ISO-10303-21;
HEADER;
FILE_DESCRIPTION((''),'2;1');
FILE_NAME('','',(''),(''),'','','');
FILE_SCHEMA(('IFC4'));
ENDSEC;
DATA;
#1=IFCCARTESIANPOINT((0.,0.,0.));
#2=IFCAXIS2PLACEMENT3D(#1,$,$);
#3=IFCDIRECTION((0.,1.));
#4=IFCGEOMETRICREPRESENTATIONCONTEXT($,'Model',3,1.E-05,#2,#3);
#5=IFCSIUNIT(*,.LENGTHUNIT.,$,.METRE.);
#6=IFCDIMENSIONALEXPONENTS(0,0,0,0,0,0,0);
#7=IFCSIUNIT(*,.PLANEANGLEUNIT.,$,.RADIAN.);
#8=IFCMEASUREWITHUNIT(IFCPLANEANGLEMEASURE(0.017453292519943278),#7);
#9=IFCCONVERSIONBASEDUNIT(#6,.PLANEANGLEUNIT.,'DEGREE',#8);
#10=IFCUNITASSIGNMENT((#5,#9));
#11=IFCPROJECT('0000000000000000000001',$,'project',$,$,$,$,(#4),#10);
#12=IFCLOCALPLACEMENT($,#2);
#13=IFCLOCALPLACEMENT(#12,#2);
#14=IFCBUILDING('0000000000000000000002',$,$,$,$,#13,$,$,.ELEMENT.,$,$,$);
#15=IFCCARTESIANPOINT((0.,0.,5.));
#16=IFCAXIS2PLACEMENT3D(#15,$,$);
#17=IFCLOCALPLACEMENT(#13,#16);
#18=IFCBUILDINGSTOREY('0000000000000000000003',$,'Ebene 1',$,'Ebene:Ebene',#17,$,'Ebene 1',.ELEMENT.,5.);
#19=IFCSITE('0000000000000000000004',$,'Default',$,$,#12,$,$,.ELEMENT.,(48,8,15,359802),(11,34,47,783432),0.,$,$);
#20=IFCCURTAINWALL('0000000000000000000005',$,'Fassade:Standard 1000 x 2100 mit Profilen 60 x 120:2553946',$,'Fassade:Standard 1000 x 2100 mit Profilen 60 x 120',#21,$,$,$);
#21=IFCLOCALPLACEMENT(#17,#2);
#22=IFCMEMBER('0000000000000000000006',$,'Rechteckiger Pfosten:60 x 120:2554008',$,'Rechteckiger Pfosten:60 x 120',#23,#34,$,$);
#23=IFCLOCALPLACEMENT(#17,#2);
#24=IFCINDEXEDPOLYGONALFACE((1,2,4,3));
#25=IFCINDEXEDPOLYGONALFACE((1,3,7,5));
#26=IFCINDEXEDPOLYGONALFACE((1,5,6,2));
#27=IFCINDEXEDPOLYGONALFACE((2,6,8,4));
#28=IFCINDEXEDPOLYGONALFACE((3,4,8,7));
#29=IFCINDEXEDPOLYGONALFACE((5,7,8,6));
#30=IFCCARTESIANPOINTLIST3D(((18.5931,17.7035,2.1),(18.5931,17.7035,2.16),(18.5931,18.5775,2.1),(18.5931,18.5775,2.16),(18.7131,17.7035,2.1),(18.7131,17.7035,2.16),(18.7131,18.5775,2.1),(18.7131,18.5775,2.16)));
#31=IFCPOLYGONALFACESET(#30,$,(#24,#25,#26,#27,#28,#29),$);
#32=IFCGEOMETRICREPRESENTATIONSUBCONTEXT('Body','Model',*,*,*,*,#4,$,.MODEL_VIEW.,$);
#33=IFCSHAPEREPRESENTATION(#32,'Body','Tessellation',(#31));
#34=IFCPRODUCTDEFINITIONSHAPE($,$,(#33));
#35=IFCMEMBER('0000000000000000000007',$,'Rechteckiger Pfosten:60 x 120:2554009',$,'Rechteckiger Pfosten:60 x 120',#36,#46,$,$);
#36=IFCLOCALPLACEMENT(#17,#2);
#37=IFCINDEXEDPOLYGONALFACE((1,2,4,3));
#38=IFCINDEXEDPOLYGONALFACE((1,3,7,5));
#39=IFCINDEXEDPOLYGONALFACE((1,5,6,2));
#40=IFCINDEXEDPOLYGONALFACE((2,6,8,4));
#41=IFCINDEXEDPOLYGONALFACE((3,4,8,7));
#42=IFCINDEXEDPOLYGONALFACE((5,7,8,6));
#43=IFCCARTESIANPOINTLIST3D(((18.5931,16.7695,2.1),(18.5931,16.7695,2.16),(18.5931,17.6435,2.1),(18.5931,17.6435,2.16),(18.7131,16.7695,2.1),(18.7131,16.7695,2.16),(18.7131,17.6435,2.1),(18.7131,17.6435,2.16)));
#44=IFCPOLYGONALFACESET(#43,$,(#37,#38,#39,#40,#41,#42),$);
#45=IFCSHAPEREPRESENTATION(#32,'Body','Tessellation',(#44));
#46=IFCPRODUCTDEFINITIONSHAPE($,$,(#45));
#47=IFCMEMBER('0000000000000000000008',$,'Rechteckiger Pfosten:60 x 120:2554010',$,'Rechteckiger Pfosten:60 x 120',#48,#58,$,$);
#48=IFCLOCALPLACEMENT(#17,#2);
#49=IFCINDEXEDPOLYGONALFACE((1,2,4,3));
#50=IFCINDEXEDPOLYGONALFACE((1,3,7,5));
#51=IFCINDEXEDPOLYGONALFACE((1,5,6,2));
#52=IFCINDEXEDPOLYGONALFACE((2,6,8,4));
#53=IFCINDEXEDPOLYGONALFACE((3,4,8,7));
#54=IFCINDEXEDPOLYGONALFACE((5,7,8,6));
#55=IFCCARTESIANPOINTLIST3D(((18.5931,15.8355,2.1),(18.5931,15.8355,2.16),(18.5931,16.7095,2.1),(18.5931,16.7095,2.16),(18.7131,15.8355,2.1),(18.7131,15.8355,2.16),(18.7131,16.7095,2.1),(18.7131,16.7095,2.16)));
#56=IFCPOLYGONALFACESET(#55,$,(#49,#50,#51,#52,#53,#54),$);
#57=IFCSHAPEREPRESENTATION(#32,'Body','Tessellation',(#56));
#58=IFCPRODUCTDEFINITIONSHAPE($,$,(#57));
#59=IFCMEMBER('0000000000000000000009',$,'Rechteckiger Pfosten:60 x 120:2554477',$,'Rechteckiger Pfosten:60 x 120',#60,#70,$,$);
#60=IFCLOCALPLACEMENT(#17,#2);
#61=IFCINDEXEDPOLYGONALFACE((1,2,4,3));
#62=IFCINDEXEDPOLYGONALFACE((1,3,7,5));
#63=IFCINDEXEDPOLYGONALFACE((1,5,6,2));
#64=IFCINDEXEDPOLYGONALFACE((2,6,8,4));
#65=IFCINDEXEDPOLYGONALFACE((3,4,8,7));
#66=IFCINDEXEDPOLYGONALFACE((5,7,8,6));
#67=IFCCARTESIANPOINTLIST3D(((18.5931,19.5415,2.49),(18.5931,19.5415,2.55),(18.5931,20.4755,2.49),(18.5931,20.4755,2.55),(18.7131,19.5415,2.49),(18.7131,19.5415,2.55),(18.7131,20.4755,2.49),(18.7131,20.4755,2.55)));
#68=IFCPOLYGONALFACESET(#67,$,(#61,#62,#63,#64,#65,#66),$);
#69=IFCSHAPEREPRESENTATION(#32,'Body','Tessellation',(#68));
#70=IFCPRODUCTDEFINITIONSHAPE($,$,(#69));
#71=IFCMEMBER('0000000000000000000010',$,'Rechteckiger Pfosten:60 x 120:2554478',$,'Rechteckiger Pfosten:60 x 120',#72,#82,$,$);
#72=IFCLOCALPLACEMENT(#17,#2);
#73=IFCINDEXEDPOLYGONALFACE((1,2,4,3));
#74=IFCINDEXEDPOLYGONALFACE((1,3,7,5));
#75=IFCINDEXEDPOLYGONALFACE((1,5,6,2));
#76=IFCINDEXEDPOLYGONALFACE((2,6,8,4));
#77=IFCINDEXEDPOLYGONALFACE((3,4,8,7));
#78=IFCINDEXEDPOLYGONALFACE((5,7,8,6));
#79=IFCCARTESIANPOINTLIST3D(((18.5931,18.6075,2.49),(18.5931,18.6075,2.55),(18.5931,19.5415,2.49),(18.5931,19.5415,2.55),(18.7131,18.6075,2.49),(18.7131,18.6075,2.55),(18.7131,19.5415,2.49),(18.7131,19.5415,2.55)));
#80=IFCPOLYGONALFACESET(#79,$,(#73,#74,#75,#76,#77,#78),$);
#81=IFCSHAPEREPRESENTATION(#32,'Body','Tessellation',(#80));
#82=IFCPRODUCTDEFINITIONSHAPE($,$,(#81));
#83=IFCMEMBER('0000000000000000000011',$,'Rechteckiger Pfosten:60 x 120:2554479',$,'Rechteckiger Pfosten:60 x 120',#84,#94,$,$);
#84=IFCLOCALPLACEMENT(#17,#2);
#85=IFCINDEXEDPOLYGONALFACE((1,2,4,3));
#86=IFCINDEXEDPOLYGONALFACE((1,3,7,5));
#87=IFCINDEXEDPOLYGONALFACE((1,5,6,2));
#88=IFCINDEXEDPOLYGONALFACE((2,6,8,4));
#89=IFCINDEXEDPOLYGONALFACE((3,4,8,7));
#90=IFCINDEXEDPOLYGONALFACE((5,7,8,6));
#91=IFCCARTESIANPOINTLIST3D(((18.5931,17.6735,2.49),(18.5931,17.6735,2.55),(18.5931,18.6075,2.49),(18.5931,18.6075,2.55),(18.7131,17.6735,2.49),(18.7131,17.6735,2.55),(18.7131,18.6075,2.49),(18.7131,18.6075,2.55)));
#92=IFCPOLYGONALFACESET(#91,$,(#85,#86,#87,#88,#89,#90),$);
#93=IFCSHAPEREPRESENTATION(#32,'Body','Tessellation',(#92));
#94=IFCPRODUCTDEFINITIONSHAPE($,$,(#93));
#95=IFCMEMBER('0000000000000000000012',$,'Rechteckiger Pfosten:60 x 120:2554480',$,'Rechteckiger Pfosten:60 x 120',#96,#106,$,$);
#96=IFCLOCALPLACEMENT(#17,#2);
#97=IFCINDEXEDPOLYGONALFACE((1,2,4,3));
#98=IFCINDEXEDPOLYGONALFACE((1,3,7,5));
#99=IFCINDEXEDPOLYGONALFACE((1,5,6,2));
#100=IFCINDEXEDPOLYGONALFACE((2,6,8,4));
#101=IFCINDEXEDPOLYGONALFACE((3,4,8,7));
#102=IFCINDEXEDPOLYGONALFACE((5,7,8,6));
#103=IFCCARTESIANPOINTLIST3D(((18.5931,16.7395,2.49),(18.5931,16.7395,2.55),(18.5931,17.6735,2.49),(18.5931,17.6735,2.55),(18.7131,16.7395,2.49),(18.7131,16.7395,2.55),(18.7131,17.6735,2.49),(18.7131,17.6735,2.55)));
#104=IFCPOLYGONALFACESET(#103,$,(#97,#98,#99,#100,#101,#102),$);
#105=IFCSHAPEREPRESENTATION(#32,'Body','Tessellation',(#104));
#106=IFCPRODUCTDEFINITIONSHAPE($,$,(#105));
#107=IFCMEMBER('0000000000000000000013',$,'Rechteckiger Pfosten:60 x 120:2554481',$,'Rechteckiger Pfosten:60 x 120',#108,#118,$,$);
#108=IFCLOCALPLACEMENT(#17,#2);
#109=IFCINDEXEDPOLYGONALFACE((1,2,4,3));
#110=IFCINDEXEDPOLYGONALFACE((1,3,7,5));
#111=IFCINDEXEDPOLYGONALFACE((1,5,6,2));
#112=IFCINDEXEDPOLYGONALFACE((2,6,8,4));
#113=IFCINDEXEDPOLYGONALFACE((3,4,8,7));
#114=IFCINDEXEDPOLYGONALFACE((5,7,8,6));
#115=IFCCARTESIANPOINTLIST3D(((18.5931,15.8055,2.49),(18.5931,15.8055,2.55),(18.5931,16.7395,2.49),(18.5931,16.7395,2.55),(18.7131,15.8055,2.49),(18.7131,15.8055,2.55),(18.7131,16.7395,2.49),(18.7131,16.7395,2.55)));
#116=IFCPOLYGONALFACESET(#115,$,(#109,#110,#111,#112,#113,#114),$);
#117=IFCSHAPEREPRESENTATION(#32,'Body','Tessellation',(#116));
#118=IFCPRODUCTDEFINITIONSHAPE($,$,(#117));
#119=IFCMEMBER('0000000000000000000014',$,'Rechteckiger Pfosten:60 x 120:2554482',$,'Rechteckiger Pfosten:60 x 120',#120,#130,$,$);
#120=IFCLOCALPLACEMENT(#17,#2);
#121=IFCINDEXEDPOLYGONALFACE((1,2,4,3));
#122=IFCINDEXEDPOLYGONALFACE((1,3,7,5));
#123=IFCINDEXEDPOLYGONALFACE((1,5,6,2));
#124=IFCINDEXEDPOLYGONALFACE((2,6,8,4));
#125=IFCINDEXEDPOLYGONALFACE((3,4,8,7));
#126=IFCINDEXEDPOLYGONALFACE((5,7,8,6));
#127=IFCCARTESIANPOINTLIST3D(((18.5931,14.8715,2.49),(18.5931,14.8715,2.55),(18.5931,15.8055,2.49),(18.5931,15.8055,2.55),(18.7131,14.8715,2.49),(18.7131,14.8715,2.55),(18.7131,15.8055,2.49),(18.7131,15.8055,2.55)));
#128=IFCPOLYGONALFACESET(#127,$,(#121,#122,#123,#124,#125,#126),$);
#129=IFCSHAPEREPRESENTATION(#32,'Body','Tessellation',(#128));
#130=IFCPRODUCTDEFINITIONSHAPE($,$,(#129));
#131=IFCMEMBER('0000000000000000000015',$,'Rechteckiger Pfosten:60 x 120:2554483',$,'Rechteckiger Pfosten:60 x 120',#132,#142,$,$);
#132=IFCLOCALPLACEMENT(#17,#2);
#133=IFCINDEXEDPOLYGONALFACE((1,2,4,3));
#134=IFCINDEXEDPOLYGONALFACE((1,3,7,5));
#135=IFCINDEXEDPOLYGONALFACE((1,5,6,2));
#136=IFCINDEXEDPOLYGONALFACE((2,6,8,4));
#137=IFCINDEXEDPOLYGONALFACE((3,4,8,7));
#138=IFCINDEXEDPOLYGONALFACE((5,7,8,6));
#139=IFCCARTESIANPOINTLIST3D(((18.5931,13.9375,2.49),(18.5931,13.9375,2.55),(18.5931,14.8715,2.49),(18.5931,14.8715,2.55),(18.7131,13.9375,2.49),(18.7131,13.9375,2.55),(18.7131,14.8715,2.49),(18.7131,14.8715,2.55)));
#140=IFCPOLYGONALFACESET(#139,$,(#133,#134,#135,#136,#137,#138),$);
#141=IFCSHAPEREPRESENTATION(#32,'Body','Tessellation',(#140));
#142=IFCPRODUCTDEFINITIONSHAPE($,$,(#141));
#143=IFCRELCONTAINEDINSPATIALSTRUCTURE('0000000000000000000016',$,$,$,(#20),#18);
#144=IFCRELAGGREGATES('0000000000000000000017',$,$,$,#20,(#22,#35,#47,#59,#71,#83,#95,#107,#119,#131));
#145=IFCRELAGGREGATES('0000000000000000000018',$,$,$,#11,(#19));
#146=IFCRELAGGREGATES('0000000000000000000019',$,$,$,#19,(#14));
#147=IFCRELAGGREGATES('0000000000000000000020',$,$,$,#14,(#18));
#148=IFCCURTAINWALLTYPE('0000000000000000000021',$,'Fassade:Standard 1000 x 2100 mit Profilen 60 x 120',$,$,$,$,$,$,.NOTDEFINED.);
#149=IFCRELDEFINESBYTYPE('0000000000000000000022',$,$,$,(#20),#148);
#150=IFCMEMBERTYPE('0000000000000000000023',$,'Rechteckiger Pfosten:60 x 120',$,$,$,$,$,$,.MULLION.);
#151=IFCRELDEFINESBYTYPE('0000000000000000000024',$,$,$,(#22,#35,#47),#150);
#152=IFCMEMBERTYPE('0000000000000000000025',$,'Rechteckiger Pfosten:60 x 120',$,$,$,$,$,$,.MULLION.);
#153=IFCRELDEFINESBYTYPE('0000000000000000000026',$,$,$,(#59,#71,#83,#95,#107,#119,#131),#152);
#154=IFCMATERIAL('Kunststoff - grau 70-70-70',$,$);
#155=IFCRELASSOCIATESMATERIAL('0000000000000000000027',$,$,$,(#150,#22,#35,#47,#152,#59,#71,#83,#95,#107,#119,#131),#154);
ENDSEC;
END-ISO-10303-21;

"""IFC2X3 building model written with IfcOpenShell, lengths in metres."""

from ifc_helpers import new_model, entity, si_unit, converted_unit, direction, frame, frame_2d, origin, origin_2d_with_axis, place, context, subcontext, project, spatial, rectangle, extrude, source, transform, mapped, material, type_object, type_shapes, element, aggregate, save


model = new_model("IFC2X3")

# Units and contexts
model_context = context("Model", 3, precision=1e-05, world=origin(), true_north=direction((0.0, 1.0)))
body_context = subcontext(model_context, "Body", "Model", "MODEL_VIEW")
ifc_project = project(units=[si_unit("LENGTHUNIT", "METRE"), converted_unit("PLANEANGLEUNIT", "DEGREE", entity("IfcPlaneAngleMeasure", 0.017453292519943278), si_unit("PLANEANGLEUNIT", "RADIAN"), dimensions=[0, 0, 0, 0, 0, 0, 0])], contexts=[model_context])

# Site, building, storey
site_placement = place(None, origin())
site = spatial("IfcSite", under=ifc_project, at=site_placement, Name="Default", CompositionType="ELEMENT", RefLatitude=(48, 8, 15, 359802), RefLongitude=(11, 34, 47, 783432), RefElevation=0.0)
building_placement = place(site_placement, origin())
building = spatial("IfcBuilding", under=site, at=building_placement, CompositionType="ELEMENT")
storey_placement = place(building_placement, frame((0.0, 0.0, 5.0)))
storey = spatial("IfcBuildingStorey", under=building, at=storey_placement, Name="Ebene 1", ObjectType="Ebene:Ebene", LongName="Ebene 1", CompositionType="ELEMENT", Elevation=5.0)

# Shared definitions
curtain_wall_type = type_object("IfcCurtainWallType", Name="Fassade:Standard 1000 x 2100 mit Profilen 60 x 120", PredefinedType="NOTDEFINED")
ifc_material_1 = material(Name="Kunststoff - grau 70-70-70")

# Curtain wall
curtain_wall_1_placement = place(storey_placement, frame((0.0, 0.0, -5.0)))
curtain_wall_1 = element("IfcCurtainWall", 1, at=curtain_wall_1_placement, inside=storey, type_object=curtain_wall_type, Name="Fassade:Standard 1000 x 2100 mit Profilen 60 x 120:2553946", ObjectType="Fassade:Standard 1000 x 2100 mit Profilen 60 x 120")

# Members
member_type_1 = type_object("IfcMemberType", Name="Rechteckiger Pfosten:60 x 120", PredefinedType="MULLION", material=ifc_material_1)
shared_shape_1 = source(origin(), body_context, "Body", "SweptSolid", [
    extrude(rectangle(XDim=0.06, YDim=0.12, at=frame_2d((0.0, 0.0), x_axis=(1.0, 0.0))), frame((0.0, 0.0, -0.874), z_axis=(0.0, 0.0, 1.0), x_axis=(-1.0, 0.0, 0.0)), (0.0, 0.0, 1.0), 0.874),
])
type_shapes(member_type_1, [shared_shape_1])
member_1_placement = place(curtain_wall_1_placement, frame((18.6531, 17.7035, 7.13), z_axis=(0.0, -1.0, 0.0), x_axis=(0.0, 0.0, 1.0)))
member_1 = element("IfcMember", 2, at=member_1_placement, type_object=member_type_1, material=ifc_material_1, Name="Rechteckiger Pfosten:60 x 120:2554008", ObjectType="Rechteckiger Pfosten:60 x 120", context=body_context, shape_type="MappedRepresentation", body=[
    mapped(shared_shape_1, transform((0.0, 0.0, 0.0), scale=1.0)),
])
member_2_placement = place(curtain_wall_1_placement, frame((18.6531, 16.7695, 7.13), z_axis=(0.0, -1.0, 0.0), x_axis=(0.0, 0.0, 1.0)))
member_2 = element("IfcMember", 3, at=member_2_placement, type_object=member_type_1, material=ifc_material_1, Name="Rechteckiger Pfosten:60 x 120:2554009", ObjectType="Rechteckiger Pfosten:60 x 120", context=body_context, shape_type="MappedRepresentation", body=[
    mapped(shared_shape_1, transform((0.0, 0.0, 0.0), scale=1.0)),
])
member_3_placement = place(curtain_wall_1_placement, frame((18.6531, 15.8355, 7.13), z_axis=(0.0, -1.0, 0.0), x_axis=(0.0, 0.0, 1.0)))
member_3 = element("IfcMember", 4, at=member_3_placement, type_object=member_type_1, material=ifc_material_1, Name="Rechteckiger Pfosten:60 x 120:2554010", ObjectType="Rechteckiger Pfosten:60 x 120", context=body_context, shape_type="MappedRepresentation", body=[
    mapped(shared_shape_1, transform((0.0, 0.0, 0.0), scale=1.0)),
])
member_type_2 = type_object("IfcMemberType", Name="Rechteckiger Pfosten:60 x 120", PredefinedType="MULLION", material=ifc_material_1)
shared_shape_2 = source(origin(), body_context, "Body", "SweptSolid", [
    extrude(rectangle(XDim=0.06, YDim=0.12, at=origin_2d_with_axis()), frame((-0.03, 0.0, -0.934), z_axis=(0.0, 0.0, 1.0), x_axis=(-1.0, 0.0, 0.0)), (0.0, 0.0, 1.0), 0.934),
])
type_shapes(member_type_2, [shared_shape_2])
member_4_placement = place(curtain_wall_1_placement, frame((18.6531, 19.5415, 7.55), z_axis=(0.0, -1.0, 0.0), x_axis=(0.0, 0.0, 1.0)))
member_4 = element("IfcMember", 5, at=member_4_placement, type_object=member_type_2, material=ifc_material_1, Name="Rechteckiger Pfosten:60 x 120:2554477", ObjectType="Rechteckiger Pfosten:60 x 120", context=body_context, shape_type="MappedRepresentation", body=[
    mapped(shared_shape_2, transform((0.0, 0.0, 0.0), scale=1.0)),
])
member_5_placement = place(curtain_wall_1_placement, frame((18.6531, 18.6075, 7.55), z_axis=(0.0, -1.0, 0.0), x_axis=(0.0, 0.0, 1.0)))
member_5 = element("IfcMember", 6, at=member_5_placement, type_object=member_type_2, material=ifc_material_1, Name="Rechteckiger Pfosten:60 x 120:2554478", ObjectType="Rechteckiger Pfosten:60 x 120", context=body_context, shape_type="MappedRepresentation", body=[
    mapped(shared_shape_2, transform((0.0, 0.0, 0.0), scale=1.0)),
])
member_6_placement = place(curtain_wall_1_placement, frame((18.6531, 17.6735, 7.55), z_axis=(0.0, -1.0, 0.0), x_axis=(0.0, 0.0, 1.0)))
member_6 = element("IfcMember", 7, at=member_6_placement, type_object=member_type_2, material=ifc_material_1, Name="Rechteckiger Pfosten:60 x 120:2554479", ObjectType="Rechteckiger Pfosten:60 x 120", context=body_context, shape_type="MappedRepresentation", body=[
    mapped(shared_shape_2, transform((0.0, 0.0, 0.0), scale=1.0)),
])
member_7_placement = place(curtain_wall_1_placement, frame((18.6531, 16.7395, 7.55), z_axis=(0.0, -1.0, 0.0), x_axis=(0.0, 0.0, 1.0)))
member_7 = element("IfcMember", 8, at=member_7_placement, type_object=member_type_2, material=ifc_material_1, Name="Rechteckiger Pfosten:60 x 120:2554480", ObjectType="Rechteckiger Pfosten:60 x 120", context=body_context, shape_type="MappedRepresentation", body=[
    mapped(shared_shape_2, transform((0.0, 0.0, 0.0), scale=1.0)),
])
member_8_placement = place(curtain_wall_1_placement, frame((18.6531, 15.8055, 7.55), z_axis=(0.0, -1.0, 0.0), x_axis=(0.0, 0.0, 1.0)))
member_8 = element("IfcMember", 9, at=member_8_placement, type_object=member_type_2, material=ifc_material_1, Name="Rechteckiger Pfosten:60 x 120:2554481", ObjectType="Rechteckiger Pfosten:60 x 120", context=body_context, shape_type="MappedRepresentation", body=[
    mapped(shared_shape_2, transform((0.0, 0.0, 0.0), scale=1.0)),
])
member_9_placement = place(curtain_wall_1_placement, frame((18.6531, 14.8715, 7.55), z_axis=(0.0, -1.0, 0.0), x_axis=(0.0, 0.0, 1.0)))
member_9 = element("IfcMember", 10, at=member_9_placement, type_object=member_type_2, material=ifc_material_1, Name="Rechteckiger Pfosten:60 x 120:2554482", ObjectType="Rechteckiger Pfosten:60 x 120", context=body_context, shape_type="MappedRepresentation", body=[
    mapped(shared_shape_2, transform((0.0, 0.0, 0.0), scale=1.0)),
])
member_10_placement = place(curtain_wall_1_placement, frame((18.6531, 13.9375, 7.55), z_axis=(0.0, -1.0, 0.0), x_axis=(0.0, 0.0, 1.0)))
member_10 = element("IfcMember", 11, at=member_10_placement, type_object=member_type_2, material=ifc_material_1, Name="Rechteckiger Pfosten:60 x 120:2554483", ObjectType="Rechteckiger Pfosten:60 x 120", context=body_context, shape_type="MappedRepresentation", body=[
    mapped(shared_shape_2, transform((0.0, 0.0, 0.0), scale=1.0)),
])

aggregate(curtain_wall_1, [member_1, member_2, member_3, member_4, member_5, member_6, member_7, member_8, member_9, member_10])

save(model, "model.ifc")
